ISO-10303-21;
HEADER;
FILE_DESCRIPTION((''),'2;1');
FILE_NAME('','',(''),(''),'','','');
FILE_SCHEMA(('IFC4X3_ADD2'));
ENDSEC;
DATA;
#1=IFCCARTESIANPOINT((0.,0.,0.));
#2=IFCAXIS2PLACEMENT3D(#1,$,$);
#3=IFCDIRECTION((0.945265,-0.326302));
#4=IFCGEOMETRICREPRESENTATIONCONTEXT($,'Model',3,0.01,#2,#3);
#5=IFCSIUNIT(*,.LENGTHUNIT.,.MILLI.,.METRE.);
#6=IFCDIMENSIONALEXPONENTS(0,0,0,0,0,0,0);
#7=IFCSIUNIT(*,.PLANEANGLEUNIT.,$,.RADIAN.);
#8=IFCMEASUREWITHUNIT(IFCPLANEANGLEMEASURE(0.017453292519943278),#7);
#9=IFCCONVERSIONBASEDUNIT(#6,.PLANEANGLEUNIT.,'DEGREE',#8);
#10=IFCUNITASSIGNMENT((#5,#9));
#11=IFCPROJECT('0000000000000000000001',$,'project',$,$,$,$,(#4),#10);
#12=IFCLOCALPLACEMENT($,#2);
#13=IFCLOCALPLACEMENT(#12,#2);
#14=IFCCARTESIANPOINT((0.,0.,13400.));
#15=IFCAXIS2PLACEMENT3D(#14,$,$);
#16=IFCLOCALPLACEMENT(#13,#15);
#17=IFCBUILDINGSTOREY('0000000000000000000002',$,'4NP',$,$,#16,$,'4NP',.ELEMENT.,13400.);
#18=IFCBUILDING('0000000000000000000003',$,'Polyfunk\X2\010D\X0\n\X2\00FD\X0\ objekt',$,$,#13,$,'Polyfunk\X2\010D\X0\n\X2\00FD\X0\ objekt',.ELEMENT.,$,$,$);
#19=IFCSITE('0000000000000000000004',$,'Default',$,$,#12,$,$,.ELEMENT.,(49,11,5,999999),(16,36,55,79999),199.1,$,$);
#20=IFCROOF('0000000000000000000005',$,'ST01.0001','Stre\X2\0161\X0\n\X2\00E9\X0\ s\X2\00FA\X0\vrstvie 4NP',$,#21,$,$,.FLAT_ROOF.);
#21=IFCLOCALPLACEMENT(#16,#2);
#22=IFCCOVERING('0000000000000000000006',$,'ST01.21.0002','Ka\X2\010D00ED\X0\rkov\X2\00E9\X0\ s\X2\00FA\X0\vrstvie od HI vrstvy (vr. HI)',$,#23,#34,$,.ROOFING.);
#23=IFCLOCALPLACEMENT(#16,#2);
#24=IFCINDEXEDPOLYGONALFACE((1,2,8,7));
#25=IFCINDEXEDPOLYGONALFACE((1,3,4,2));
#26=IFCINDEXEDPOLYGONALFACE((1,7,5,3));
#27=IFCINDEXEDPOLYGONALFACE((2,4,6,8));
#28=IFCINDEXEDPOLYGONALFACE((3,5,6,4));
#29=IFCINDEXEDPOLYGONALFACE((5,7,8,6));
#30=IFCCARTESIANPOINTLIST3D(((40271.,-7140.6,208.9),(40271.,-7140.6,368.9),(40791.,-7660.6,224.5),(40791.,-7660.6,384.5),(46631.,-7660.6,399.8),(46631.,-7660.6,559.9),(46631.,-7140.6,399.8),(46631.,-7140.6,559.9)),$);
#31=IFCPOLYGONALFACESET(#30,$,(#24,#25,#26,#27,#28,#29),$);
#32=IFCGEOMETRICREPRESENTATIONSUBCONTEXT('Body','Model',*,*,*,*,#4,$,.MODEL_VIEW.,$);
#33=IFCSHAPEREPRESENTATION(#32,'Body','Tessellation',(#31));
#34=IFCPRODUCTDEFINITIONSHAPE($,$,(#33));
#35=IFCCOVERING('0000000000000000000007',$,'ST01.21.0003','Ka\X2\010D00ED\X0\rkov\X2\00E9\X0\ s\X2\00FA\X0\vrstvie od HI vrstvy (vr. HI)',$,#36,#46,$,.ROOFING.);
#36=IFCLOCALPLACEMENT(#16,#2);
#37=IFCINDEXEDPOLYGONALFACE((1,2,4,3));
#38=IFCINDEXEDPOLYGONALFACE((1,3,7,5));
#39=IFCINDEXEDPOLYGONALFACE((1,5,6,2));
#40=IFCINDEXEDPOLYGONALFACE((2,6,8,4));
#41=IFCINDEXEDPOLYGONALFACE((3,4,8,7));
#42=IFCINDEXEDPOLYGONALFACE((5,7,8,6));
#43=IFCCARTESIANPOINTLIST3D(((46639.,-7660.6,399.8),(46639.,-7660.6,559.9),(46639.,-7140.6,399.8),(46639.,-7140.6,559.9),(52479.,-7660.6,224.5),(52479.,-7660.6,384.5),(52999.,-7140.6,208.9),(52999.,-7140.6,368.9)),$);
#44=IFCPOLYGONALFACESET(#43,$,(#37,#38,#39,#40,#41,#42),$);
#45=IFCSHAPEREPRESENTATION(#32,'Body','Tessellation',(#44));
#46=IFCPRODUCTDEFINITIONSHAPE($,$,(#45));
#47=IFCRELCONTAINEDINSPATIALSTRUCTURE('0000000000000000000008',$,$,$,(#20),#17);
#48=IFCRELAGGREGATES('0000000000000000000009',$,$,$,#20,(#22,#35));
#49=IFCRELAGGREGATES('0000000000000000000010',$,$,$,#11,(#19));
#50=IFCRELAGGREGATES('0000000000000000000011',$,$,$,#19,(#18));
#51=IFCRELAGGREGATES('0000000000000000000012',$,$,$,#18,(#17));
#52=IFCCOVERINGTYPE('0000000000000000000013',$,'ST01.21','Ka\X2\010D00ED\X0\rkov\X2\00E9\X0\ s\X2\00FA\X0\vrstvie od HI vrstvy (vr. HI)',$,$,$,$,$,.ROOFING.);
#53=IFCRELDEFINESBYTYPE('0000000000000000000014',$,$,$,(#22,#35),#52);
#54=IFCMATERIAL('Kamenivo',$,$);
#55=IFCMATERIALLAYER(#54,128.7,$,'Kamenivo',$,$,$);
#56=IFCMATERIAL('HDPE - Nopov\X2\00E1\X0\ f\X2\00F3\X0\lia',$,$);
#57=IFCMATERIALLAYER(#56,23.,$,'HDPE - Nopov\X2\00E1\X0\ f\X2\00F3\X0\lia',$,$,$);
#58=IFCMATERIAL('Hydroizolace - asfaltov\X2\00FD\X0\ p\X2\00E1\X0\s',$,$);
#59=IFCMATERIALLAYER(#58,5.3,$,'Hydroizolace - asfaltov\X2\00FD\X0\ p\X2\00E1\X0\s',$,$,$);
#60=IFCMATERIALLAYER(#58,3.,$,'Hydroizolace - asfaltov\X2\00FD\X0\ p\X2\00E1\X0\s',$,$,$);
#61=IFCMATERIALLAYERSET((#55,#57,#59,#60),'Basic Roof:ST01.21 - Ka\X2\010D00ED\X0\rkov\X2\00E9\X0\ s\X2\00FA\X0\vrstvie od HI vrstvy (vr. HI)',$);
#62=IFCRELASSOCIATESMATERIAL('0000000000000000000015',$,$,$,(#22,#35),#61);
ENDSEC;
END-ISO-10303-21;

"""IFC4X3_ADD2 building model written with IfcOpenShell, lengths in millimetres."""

from ifc_helpers import new_model, entity, si_unit, converted_unit, direction, frame, origin, place, context, subcontext, project, spatial, polyline, outline, extrude, material, layer, layer_set, type_object, element, aggregate, save


model = new_model("IFC4X3_ADD2")

# Units and contexts
model_context = context("Model", 3, precision=0.01, world=origin(), true_north=direction((0.945265, -0.326302)))
body_context = subcontext(model_context, "Body", "Model", "MODEL_VIEW")
ifc_project = project(units=[si_unit("LENGTHUNIT", "METRE", prefix="MILLI"), converted_unit("PLANEANGLEUNIT", "DEGREE", entity("IfcPlaneAngleMeasure", 0.017453292519943278), si_unit("PLANEANGLEUNIT", "RADIAN"), dimensions=[0, 0, 0, 0, 0, 0, 0])], contexts=[model_context])

# Site, building, storey
site_placement = place(None, origin())
site = spatial("IfcSite", under=ifc_project, at=site_placement, Name="Default", CompositionType="ELEMENT", RefLatitude=(49, 11, 5, 999999), RefLongitude=(16, 36, 55, 79999), RefElevation=199.1)
building_placement = place(site_placement, origin())
building = spatial("IfcBuilding", under=site, at=building_placement, Name="Polyfunkčný objekt", LongName="Polyfunkčný objekt", CompositionType="ELEMENT")
storey_placement = place(building_placement, frame((0.0, 0.0, 13400.0)))
storey = spatial("IfcBuildingStorey", under=building, at=storey_placement, Name="4NP", LongName="4NP", CompositionType="ELEMENT", Elevation=13400.0)

# Roof, coverings
roof = element("IfcRoof", 1, inside=storey, Name="ST01.0001", Description="Strešné súvrstvie 4NP", PredefinedType="FLAT_ROOF")
ifc_material_1 = material(Name="Hydroizolace - asfaltový pás")
ifc_material_2 = material(Name="Kamenivo")
ifc_layer_1 = layer(ifc_material_2, 128.7, Name="Kamenivo")
ifc_material_3 = material(Name="HDPE - Nopová fólia")
ifc_layer_2 = layer(ifc_material_3, 23.0, Name="HDPE - Nopová fólia")
ifc_layer_3 = layer(ifc_material_1, 5.3, Name="Hydroizolace - asfaltový pás")
ifc_layer_4 = layer(ifc_material_1, 3.0, Name="Hydroizolace - asfaltový pás")
ifc_layer_set_1 = layer_set([ifc_layer_1, ifc_layer_2, ifc_layer_3, ifc_layer_4], Name="Basic Roof:ST01.21 - Kačírkové súvrstvie od HI vrstvy (vr. HI)")
covering_type_1 = type_object("IfcCoveringType", Name="ST01.21", Description="Kačírkové súvrstvie od HI vrstvy (vr. HI)", PredefinedType="ROOFING")
placement_1 = place(storey_placement, frame((40271.0, -7660.6, 208.9)))
covering_1_placement = place(placement_1, origin())
covering_1 = element("IfcCovering", 2, at=covering_1_placement, type_object=covering_type_1, material=ifc_layer_set_1, Name="ST01.21.0002", Description="Kačírkové súvrstvie od HI vrstvy (vr. HI)", PredefinedType="ROOFING", context=body_context, shape_type="SweptSolid", body=[
    extrude(outline(polyline([(-2661.2, -260.0), (3181.4, -260.0), (3181.4, 260.0), (-3181.4, 260.0), (-2661.2, -260.0)])), frame((3180.0, 260.0, 95.5), z_axis=(-0.030015, 0.0, 0.999549), x_axis=(0.999549, 0.0, 0.030015)), (0.030015, 0.0, 0.999549), 160.1),
])
placement_2 = place(storey_placement, frame((46639.0, -7660.6, 208.9)))
covering_2_placement = place(placement_2, origin())
covering_2 = element("IfcCovering", 3, at=covering_2_placement, type_object=covering_type_1, material=ifc_layer_set_1, Name="ST01.21.0003", Description="Kačírkové súvrstvie od HI vrstvy (vr. HI)", PredefinedType="ROOFING", context=body_context, shape_type="SweptSolid", body=[
    extrude(outline(polyline([(3181.4, 260.0), (-3181.4, 260.0), (-3181.4, -260.0), (2661.2, -260.0), (3181.4, 260.0)])), frame((3180.0, 260.0, 95.5), z_axis=(0.030015, 0.0, 0.999549), x_axis=(0.999549, 0.0, -0.030015)), (-0.030015, 0.0, 0.999549), 160.1),
])
aggregate(roof, [covering_1, covering_2])

save(model, "model.ifc")
